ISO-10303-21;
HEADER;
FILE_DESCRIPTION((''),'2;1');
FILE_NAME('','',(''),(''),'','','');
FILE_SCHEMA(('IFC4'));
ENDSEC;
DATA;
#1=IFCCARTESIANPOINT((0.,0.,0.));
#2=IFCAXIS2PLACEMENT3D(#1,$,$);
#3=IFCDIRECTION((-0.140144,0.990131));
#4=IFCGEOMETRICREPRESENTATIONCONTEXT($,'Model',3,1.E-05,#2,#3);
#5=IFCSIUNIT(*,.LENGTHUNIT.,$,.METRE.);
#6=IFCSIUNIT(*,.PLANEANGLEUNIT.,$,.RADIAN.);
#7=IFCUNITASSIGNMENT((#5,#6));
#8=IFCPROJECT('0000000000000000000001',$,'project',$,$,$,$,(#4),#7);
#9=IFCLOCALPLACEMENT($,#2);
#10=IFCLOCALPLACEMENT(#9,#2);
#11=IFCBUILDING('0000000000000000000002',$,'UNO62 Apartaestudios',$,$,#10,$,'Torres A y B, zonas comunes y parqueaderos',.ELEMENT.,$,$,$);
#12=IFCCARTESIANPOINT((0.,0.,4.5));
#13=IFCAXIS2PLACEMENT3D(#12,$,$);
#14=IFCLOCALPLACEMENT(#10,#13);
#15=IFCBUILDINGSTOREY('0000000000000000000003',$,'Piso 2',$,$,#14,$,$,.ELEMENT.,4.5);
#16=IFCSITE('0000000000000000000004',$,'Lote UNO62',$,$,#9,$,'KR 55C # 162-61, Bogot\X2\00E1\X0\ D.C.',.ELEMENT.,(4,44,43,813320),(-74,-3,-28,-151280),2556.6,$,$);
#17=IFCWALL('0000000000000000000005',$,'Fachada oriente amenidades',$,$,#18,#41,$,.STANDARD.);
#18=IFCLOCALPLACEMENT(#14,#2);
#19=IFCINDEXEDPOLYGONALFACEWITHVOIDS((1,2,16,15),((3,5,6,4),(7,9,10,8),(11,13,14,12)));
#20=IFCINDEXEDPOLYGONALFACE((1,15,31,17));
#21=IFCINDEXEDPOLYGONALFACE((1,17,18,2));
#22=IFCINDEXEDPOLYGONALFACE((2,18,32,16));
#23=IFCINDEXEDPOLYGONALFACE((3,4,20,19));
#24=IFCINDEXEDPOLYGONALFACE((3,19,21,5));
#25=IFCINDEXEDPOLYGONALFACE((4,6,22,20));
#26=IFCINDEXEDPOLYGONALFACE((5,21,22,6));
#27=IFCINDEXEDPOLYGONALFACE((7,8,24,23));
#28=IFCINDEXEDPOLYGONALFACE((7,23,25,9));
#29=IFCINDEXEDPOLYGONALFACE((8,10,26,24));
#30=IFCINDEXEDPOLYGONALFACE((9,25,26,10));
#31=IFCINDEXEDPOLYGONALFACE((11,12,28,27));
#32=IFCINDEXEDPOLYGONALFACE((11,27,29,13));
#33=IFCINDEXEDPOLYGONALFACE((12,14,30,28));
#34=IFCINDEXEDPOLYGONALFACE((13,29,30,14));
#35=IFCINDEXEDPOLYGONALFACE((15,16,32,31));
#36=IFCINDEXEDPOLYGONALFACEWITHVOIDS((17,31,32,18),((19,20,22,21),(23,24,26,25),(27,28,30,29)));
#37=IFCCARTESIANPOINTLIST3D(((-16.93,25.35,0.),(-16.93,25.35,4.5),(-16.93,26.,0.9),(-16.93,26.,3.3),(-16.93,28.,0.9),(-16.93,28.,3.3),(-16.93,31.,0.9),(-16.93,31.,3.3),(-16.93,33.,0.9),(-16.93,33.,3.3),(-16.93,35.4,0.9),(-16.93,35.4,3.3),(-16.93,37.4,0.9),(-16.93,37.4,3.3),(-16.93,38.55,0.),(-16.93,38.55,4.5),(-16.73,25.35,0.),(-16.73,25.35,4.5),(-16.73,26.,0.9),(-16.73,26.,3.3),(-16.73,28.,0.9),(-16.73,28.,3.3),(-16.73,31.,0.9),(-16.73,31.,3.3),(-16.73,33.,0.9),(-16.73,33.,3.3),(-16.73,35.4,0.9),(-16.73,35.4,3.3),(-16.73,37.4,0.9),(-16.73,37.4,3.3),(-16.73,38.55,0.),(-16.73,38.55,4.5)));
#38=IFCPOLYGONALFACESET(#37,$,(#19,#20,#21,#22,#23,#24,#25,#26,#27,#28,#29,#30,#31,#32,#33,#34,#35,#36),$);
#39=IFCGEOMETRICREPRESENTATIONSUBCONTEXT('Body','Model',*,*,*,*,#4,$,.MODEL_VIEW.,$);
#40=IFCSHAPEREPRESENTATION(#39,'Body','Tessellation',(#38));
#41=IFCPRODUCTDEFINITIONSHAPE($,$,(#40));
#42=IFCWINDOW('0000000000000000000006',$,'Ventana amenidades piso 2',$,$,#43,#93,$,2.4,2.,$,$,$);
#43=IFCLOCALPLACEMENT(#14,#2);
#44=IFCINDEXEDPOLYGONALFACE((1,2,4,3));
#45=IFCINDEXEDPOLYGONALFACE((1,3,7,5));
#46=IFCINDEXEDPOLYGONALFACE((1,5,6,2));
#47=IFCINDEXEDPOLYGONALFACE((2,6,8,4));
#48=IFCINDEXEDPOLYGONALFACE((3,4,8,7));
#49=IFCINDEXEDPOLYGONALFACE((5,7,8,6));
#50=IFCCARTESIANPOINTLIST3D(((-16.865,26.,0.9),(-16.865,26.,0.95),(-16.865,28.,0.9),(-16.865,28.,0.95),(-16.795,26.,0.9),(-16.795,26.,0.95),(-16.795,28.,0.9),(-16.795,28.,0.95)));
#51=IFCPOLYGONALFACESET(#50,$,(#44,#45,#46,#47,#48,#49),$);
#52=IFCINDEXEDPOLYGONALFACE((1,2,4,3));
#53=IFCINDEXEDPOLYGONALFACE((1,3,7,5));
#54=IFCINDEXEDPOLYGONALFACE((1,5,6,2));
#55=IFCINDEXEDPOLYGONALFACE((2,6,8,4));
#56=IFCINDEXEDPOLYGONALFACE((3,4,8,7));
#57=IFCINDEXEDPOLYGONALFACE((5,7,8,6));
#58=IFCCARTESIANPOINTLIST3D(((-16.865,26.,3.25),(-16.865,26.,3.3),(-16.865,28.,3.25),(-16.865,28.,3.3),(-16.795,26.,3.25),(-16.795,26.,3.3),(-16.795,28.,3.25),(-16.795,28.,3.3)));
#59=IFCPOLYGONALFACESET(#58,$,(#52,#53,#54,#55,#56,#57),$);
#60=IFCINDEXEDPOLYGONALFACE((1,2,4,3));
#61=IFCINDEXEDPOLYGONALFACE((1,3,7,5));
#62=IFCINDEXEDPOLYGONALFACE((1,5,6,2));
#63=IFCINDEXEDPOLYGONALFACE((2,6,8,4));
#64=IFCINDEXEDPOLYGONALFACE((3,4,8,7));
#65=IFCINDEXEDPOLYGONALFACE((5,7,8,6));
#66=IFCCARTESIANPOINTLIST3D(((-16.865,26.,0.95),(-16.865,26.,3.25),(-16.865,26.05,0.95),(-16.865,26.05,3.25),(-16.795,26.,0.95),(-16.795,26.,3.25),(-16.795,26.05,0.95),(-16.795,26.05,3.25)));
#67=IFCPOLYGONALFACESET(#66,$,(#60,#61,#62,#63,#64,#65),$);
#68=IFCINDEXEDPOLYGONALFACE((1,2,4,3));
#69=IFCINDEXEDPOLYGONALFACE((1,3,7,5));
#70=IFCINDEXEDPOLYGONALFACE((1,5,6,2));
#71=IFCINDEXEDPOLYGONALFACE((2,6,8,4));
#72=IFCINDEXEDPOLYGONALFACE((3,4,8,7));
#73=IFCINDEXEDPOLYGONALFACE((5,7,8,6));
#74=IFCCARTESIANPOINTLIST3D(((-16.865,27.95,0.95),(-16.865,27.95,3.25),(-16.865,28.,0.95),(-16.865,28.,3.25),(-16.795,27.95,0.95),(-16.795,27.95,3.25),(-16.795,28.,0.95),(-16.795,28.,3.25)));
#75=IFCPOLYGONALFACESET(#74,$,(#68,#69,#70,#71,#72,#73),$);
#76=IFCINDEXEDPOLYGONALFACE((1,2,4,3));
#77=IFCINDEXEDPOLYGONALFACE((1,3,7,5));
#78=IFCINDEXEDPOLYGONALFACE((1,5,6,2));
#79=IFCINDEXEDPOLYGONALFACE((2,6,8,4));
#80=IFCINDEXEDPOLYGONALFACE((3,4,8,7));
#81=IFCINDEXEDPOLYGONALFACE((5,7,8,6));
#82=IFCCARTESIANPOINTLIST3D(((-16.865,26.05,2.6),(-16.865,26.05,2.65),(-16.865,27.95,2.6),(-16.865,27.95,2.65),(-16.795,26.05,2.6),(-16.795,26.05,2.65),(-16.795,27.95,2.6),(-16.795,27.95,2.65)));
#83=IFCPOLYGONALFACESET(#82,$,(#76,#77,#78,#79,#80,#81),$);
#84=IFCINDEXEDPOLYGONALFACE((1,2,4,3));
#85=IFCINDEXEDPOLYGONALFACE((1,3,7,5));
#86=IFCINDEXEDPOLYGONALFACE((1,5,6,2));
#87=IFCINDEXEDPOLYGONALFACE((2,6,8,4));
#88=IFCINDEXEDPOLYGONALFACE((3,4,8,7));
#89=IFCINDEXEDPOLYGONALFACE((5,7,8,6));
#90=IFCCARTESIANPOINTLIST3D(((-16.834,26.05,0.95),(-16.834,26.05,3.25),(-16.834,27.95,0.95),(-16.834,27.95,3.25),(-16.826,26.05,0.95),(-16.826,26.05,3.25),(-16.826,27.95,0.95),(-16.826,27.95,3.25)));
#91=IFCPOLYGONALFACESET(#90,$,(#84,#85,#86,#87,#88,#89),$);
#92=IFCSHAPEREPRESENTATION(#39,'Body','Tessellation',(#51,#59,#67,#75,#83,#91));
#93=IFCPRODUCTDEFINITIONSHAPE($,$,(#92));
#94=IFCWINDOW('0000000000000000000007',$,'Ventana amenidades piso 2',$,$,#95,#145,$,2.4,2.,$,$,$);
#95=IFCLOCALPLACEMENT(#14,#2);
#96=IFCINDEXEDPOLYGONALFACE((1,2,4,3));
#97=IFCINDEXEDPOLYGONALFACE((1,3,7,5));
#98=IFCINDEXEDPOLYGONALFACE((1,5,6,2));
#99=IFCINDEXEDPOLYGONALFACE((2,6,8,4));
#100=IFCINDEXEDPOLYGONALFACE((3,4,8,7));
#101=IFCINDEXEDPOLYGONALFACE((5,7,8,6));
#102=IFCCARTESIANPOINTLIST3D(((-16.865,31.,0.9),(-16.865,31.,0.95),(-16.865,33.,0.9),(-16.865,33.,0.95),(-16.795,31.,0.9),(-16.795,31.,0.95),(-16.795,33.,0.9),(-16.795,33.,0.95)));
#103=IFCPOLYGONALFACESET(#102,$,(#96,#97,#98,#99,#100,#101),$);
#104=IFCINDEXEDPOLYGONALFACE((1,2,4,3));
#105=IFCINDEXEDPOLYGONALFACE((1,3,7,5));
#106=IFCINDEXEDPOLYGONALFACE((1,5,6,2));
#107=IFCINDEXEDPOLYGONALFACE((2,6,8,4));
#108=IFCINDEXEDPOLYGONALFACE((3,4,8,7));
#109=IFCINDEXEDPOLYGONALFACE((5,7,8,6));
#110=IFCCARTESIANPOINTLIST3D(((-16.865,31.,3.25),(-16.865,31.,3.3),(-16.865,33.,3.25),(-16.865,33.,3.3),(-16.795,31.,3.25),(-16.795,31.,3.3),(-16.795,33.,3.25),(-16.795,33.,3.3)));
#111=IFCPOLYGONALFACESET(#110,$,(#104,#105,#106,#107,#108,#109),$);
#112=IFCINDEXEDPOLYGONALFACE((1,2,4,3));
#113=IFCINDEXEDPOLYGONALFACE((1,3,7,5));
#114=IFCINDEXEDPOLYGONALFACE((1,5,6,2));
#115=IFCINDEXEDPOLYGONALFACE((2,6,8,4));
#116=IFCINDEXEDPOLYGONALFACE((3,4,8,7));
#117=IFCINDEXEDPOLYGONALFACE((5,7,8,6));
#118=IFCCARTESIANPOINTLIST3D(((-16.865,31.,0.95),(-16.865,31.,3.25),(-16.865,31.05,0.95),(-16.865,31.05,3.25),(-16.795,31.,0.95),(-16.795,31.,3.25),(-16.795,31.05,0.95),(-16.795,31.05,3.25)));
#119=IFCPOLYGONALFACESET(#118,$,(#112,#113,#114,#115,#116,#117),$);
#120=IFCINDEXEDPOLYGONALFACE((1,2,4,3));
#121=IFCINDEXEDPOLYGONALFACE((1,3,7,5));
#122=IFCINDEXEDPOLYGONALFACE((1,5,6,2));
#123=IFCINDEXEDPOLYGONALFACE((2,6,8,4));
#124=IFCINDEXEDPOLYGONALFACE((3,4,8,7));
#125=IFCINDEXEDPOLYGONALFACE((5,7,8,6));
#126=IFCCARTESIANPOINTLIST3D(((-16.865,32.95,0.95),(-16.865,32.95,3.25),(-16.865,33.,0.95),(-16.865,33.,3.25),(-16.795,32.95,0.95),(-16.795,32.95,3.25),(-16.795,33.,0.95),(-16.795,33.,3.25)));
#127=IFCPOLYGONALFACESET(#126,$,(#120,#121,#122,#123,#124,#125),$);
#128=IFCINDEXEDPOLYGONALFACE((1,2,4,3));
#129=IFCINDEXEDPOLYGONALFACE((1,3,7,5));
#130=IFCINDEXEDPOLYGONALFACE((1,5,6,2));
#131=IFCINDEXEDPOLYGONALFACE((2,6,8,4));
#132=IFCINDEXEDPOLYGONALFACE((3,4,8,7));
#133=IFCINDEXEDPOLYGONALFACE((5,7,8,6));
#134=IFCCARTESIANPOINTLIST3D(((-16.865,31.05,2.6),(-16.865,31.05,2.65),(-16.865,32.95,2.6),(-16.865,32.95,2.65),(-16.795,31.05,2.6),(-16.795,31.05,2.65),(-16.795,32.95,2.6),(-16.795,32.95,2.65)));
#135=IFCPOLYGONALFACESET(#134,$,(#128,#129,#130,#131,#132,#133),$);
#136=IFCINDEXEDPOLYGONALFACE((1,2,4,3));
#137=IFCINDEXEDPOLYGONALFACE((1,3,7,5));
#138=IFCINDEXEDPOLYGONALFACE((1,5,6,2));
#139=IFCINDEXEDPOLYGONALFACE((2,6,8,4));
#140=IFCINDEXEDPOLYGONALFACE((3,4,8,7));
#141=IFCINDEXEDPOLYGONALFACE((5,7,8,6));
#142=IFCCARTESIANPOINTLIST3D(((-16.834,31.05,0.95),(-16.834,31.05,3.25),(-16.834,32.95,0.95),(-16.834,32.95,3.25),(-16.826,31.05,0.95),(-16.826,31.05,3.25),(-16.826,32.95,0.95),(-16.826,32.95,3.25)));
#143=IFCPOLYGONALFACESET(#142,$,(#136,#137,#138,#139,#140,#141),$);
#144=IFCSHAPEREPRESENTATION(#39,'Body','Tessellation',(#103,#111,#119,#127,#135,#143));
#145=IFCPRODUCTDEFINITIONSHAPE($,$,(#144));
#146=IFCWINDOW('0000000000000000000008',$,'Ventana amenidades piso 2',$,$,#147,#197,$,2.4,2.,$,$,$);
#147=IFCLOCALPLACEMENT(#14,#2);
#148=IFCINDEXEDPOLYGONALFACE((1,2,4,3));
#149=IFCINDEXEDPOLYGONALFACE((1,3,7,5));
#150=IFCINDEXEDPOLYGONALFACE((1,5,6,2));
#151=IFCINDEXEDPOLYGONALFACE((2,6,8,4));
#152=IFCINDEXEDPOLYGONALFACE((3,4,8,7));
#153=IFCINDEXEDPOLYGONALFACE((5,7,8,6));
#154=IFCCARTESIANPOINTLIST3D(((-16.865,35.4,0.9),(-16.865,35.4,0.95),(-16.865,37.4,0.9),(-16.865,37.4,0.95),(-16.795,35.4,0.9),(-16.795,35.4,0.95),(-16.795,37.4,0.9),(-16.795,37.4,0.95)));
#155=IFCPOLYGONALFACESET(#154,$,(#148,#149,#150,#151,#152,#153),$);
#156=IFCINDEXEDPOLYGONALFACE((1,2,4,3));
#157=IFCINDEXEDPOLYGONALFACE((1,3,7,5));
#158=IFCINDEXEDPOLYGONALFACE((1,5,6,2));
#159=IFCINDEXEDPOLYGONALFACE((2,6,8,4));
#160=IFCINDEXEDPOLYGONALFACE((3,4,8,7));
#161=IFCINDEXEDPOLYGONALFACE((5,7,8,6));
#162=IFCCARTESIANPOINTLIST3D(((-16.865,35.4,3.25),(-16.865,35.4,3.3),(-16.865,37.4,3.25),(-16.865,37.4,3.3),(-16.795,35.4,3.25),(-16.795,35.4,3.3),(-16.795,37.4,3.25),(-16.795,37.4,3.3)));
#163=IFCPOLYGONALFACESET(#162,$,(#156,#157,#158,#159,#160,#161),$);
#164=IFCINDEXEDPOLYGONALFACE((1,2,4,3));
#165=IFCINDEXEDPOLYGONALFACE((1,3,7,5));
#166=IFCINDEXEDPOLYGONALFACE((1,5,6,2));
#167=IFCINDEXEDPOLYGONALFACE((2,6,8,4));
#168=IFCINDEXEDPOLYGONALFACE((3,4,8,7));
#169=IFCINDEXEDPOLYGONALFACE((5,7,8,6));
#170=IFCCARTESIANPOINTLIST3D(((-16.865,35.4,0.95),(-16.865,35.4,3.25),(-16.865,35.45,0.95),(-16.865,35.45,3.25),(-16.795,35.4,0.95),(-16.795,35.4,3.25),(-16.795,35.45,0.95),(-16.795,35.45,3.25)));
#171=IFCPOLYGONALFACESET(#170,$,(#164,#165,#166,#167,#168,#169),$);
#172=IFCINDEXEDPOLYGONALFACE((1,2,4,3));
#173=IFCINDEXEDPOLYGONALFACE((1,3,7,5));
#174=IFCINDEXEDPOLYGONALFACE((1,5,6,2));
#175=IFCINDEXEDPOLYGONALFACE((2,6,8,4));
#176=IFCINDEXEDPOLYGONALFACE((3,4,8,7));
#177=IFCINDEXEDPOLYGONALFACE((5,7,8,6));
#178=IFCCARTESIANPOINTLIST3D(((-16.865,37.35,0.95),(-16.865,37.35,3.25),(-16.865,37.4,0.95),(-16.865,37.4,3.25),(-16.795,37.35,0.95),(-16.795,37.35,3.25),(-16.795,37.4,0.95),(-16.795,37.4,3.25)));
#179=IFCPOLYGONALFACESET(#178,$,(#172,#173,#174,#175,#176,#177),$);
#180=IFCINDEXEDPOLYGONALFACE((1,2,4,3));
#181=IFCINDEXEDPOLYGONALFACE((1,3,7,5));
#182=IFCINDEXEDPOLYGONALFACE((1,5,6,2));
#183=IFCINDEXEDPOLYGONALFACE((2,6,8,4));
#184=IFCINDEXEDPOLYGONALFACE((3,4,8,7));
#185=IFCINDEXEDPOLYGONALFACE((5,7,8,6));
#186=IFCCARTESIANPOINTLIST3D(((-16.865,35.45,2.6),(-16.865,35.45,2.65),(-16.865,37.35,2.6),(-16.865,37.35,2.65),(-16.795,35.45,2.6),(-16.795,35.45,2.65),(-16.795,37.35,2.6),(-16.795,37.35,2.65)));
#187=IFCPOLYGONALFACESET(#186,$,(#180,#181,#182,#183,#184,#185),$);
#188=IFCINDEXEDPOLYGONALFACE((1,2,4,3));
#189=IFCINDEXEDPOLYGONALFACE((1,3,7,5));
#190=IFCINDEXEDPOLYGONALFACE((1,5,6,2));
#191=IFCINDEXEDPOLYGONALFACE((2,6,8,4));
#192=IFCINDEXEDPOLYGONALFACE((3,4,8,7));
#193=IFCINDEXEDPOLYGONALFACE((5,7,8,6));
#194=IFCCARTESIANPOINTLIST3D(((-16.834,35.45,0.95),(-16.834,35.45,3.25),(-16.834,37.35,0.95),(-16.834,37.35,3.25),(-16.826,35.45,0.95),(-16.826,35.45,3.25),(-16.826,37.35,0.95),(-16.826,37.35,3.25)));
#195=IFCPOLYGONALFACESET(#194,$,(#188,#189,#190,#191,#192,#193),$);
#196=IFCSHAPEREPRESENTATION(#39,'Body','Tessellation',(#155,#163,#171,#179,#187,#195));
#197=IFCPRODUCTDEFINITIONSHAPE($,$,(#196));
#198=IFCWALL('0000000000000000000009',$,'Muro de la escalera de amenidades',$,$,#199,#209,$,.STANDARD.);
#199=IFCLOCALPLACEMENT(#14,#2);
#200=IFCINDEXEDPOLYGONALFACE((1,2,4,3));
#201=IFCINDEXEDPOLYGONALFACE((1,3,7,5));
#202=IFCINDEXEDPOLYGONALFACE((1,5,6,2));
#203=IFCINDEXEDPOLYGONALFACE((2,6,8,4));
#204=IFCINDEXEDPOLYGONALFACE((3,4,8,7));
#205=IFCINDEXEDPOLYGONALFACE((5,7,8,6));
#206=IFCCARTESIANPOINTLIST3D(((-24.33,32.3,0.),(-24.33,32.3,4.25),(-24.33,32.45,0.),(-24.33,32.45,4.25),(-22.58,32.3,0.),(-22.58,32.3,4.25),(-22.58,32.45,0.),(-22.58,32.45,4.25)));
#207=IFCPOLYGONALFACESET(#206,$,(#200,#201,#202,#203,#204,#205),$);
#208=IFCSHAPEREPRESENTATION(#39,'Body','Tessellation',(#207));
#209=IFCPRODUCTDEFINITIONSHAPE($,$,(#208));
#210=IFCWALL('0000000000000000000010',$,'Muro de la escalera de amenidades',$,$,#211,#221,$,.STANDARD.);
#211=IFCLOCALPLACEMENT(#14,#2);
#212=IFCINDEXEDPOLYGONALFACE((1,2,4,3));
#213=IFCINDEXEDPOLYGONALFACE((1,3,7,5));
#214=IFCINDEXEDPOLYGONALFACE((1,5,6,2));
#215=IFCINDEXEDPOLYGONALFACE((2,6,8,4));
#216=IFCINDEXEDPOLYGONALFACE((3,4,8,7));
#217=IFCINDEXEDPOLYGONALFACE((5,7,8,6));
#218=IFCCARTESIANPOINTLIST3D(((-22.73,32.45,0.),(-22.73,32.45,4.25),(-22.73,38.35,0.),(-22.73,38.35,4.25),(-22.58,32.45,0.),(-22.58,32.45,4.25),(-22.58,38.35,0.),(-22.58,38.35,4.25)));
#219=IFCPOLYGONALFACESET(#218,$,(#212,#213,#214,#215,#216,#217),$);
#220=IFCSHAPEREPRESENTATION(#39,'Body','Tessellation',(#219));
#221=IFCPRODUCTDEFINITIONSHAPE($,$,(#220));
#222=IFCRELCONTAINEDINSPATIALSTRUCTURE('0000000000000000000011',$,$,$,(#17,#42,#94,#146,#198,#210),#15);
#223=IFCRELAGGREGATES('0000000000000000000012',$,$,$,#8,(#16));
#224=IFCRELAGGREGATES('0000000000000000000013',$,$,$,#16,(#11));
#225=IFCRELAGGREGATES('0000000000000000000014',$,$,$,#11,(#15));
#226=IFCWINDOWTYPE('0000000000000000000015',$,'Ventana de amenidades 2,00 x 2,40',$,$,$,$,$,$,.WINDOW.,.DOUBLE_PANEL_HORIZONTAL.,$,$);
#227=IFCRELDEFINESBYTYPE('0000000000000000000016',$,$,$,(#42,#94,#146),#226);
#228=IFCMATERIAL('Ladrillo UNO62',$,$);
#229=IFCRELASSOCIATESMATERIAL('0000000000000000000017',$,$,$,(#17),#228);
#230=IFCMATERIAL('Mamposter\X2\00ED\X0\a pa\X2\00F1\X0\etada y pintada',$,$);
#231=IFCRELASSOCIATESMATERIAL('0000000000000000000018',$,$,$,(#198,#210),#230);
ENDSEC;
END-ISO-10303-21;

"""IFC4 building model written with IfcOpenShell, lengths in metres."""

from ifc_helpers import new_model, si_unit, direction, frame, frame_2d, origin, place, context, subcontext, project, spatial, rectangle, extrude, source, transform, mapped, material, type_object, type_shapes, element, fill, save


model = new_model("IFC4")

# Units and contexts
model_context = context("Model", 3, precision=1e-05, world=origin(), true_north=direction((-0.140144, 0.990131)))
body_context = subcontext(model_context, "Body", "Model", "MODEL_VIEW")
ifc_project = project(units=[si_unit("LENGTHUNIT", "METRE"), si_unit("PLANEANGLEUNIT", "RADIAN")], contexts=[model_context])

# Site, building, storey
site_placement = place(None, origin())
site = spatial("IfcSite", under=ifc_project, at=site_placement, Name="Lote UNO62", LongName="KR 55C # 162-61, Bogotá D.C.", CompositionType="ELEMENT", RefLatitude=(4, 44, 43, 813320), RefLongitude=(-74, -3, -28, -151280), RefElevation=2556.6)
building_placement = place(site_placement, origin())
building = spatial("IfcBuilding", under=site, at=building_placement, Name="UNO62 Apartaestudios", LongName="Torres A y B, zonas comunes y parqueaderos", CompositionType="ELEMENT")
storey_placement = place(building_placement, frame((0.0, 0.0, 4.5)))
storey = spatial("IfcBuildingStorey", under=building, at=storey_placement, Name="Piso 2", CompositionType="ELEMENT", Elevation=4.5)

# Shared definitions
ifc_material_1 = material(Name="Ladrillo UNO62")
window_type = type_object("IfcWindowType", Name="Ventana de amenidades 2,00 x 2,40", PartitioningType="DOUBLE_PANEL_HORIZONTAL", PredefinedType="WINDOW")
shared_shape_1 = source(origin(), body_context, "Body", "SweptSolid", [
    extrude(rectangle(XDim=2.0, YDim=0.07, at=frame_2d((1.0, 0.0))), origin(), (0.0, 0.0, 1.0), 0.05),
    extrude(rectangle(XDim=2.0, YDim=0.07, at=frame_2d((1.0, 0.0))), frame((0.0, 0.0, 2.35)), (0.0, 0.0, 1.0), 0.05),
    extrude(rectangle(XDim=0.05, YDim=0.07, at=frame_2d((0.025, 0.0))), frame((0.0, 0.0, 0.05)), (0.0, 0.0, 1.0), 2.3),
    extrude(rectangle(XDim=0.05, YDim=0.07, at=frame_2d((1.975, 0.0))), frame((0.0, 0.0, 0.05)), (0.0, 0.0, 1.0), 2.3),
    extrude(rectangle(XDim=1.9, YDim=0.07, at=frame_2d((1.0, 0.0))), frame((0.0, 0.0, 1.7)), (0.0, 0.0, 1.0), 0.05),
    extrude(rectangle(XDim=1.9, YDim=0.008, at=frame_2d((1.0, 0.0))), frame((0.0, 0.0, 0.05)), (0.0, 0.0, 1.0), 2.3),
])
type_shapes(window_type, [shared_shape_1])

# Wall, openings, windows
wall_1_placement = place(storey_placement, origin())
wall_1 = element("IfcWall", 1, at=wall_1_placement, inside=storey, material=ifc_material_1, Name="Fachada oriente amenidades", PredefinedType="STANDARD", context=body_context, shape_type="SweptSolid", body=[
    extrude(rectangle(XDim=0.2, YDim=13.2, at=frame_2d((-16.83, 31.95))), origin(), (0.0, 0.0, 1.0), 4.5),
])
opening_1_placement = place(wall_1_placement, origin())
opening_1 = element("IfcOpeningElement", 2, at=opening_1_placement, cuts=wall_1, PredefinedType="OPENING", context=body_context, shape_type="SweptSolid", body=[
    extrude(rectangle(XDim=0.3, YDim=2.0, at=frame_2d((-16.83, 27.0))), frame((0.0, 0.0, 0.9)), (0.0, 0.0, 1.0), 2.4),
])
opening_2_placement = place(wall_1_placement, origin())
opening_2 = element("IfcOpeningElement", 3, at=opening_2_placement, cuts=wall_1, PredefinedType="OPENING", context=body_context, shape_type="SweptSolid", body=[
    extrude(rectangle(XDim=0.3, YDim=2.0, at=frame_2d((-16.83, 32.0))), frame((0.0, 0.0, 0.9)), (0.0, 0.0, 1.0), 2.4),
])
opening_3_placement = place(wall_1_placement, origin())
opening_3 = element("IfcOpeningElement", 4, at=opening_3_placement, cuts=wall_1, PredefinedType="OPENING", context=body_context, shape_type="SweptSolid", body=[
    extrude(rectangle(XDim=0.3, YDim=2.0, at=frame_2d((-16.83, 36.4))), frame((0.0, 0.0, 0.9)), (0.0, 0.0, 1.0), 2.4),
])
window_1_placement = place(storey_placement, frame((-16.83, 26.0, 0.9), z_axis=(0.0, 0.0, 1.0), x_axis=(0.0, 1.0, 0.0)))
window_1 = element("IfcWindow", 5, at=window_1_placement, inside=storey, type_object=window_type, Name="Ventana amenidades piso 2", OverallHeight=2.4, OverallWidth=2.0, context=body_context, shape_type="MappedRepresentation", body=[
    mapped(shared_shape_1, transform((0.0, 0.0, 0.0))),
])
fill(opening_1, window_1)
window_2_placement = place(storey_placement, frame((-16.83, 31.0, 0.9), z_axis=(0.0, 0.0, 1.0), x_axis=(0.0, 1.0, 0.0)))
window_2 = element("IfcWindow", 6, at=window_2_placement, inside=storey, type_object=window_type, Name="Ventana amenidades piso 2", OverallHeight=2.4, OverallWidth=2.0, context=body_context, shape_type="MappedRepresentation", body=[
    mapped(shared_shape_1, transform((0.0, 0.0, 0.0))),
])
fill(opening_2, window_2)
window_3_placement = place(storey_placement, frame((-16.83, 35.4, 0.9), z_axis=(0.0, 0.0, 1.0), x_axis=(0.0, 1.0, 0.0)))
window_3 = element("IfcWindow", 7, at=window_3_placement, inside=storey, type_object=window_type, Name="Ventana amenidades piso 2", OverallHeight=2.4, OverallWidth=2.0, context=body_context, shape_type="MappedRepresentation", body=[
    mapped(shared_shape_1, transform((0.0, 0.0, 0.0))),
])
fill(opening_3, window_3)

# Walls
ifc_material_2 = material(Name="Mampostería pañetada y pintada")
wall_2_placement = place(storey_placement, origin())
element("IfcWall", 8, at=wall_2_placement, inside=storey, material=ifc_material_2, Name="Muro de la escalera de amenidades", PredefinedType="STANDARD", context=body_context, shape_type="SweptSolid", body=[
    extrude(rectangle(XDim=1.75, YDim=0.15, at=frame_2d((-23.455, 32.375))), origin(), (0.0, 0.0, 1.0), 4.25),
])
wall_3_placement = place(storey_placement, origin())
element("IfcWall", 9, at=wall_3_placement, inside=storey, material=ifc_material_2, Name="Muro de la escalera de amenidades", PredefinedType="STANDARD", context=body_context, shape_type="SweptSolid", body=[
    extrude(rectangle(XDim=0.15, YDim=5.9, at=frame_2d((-22.655, 35.4))), origin(), (0.0, 0.0, 1.0), 4.25),
])

save(model, "model.ifc")
